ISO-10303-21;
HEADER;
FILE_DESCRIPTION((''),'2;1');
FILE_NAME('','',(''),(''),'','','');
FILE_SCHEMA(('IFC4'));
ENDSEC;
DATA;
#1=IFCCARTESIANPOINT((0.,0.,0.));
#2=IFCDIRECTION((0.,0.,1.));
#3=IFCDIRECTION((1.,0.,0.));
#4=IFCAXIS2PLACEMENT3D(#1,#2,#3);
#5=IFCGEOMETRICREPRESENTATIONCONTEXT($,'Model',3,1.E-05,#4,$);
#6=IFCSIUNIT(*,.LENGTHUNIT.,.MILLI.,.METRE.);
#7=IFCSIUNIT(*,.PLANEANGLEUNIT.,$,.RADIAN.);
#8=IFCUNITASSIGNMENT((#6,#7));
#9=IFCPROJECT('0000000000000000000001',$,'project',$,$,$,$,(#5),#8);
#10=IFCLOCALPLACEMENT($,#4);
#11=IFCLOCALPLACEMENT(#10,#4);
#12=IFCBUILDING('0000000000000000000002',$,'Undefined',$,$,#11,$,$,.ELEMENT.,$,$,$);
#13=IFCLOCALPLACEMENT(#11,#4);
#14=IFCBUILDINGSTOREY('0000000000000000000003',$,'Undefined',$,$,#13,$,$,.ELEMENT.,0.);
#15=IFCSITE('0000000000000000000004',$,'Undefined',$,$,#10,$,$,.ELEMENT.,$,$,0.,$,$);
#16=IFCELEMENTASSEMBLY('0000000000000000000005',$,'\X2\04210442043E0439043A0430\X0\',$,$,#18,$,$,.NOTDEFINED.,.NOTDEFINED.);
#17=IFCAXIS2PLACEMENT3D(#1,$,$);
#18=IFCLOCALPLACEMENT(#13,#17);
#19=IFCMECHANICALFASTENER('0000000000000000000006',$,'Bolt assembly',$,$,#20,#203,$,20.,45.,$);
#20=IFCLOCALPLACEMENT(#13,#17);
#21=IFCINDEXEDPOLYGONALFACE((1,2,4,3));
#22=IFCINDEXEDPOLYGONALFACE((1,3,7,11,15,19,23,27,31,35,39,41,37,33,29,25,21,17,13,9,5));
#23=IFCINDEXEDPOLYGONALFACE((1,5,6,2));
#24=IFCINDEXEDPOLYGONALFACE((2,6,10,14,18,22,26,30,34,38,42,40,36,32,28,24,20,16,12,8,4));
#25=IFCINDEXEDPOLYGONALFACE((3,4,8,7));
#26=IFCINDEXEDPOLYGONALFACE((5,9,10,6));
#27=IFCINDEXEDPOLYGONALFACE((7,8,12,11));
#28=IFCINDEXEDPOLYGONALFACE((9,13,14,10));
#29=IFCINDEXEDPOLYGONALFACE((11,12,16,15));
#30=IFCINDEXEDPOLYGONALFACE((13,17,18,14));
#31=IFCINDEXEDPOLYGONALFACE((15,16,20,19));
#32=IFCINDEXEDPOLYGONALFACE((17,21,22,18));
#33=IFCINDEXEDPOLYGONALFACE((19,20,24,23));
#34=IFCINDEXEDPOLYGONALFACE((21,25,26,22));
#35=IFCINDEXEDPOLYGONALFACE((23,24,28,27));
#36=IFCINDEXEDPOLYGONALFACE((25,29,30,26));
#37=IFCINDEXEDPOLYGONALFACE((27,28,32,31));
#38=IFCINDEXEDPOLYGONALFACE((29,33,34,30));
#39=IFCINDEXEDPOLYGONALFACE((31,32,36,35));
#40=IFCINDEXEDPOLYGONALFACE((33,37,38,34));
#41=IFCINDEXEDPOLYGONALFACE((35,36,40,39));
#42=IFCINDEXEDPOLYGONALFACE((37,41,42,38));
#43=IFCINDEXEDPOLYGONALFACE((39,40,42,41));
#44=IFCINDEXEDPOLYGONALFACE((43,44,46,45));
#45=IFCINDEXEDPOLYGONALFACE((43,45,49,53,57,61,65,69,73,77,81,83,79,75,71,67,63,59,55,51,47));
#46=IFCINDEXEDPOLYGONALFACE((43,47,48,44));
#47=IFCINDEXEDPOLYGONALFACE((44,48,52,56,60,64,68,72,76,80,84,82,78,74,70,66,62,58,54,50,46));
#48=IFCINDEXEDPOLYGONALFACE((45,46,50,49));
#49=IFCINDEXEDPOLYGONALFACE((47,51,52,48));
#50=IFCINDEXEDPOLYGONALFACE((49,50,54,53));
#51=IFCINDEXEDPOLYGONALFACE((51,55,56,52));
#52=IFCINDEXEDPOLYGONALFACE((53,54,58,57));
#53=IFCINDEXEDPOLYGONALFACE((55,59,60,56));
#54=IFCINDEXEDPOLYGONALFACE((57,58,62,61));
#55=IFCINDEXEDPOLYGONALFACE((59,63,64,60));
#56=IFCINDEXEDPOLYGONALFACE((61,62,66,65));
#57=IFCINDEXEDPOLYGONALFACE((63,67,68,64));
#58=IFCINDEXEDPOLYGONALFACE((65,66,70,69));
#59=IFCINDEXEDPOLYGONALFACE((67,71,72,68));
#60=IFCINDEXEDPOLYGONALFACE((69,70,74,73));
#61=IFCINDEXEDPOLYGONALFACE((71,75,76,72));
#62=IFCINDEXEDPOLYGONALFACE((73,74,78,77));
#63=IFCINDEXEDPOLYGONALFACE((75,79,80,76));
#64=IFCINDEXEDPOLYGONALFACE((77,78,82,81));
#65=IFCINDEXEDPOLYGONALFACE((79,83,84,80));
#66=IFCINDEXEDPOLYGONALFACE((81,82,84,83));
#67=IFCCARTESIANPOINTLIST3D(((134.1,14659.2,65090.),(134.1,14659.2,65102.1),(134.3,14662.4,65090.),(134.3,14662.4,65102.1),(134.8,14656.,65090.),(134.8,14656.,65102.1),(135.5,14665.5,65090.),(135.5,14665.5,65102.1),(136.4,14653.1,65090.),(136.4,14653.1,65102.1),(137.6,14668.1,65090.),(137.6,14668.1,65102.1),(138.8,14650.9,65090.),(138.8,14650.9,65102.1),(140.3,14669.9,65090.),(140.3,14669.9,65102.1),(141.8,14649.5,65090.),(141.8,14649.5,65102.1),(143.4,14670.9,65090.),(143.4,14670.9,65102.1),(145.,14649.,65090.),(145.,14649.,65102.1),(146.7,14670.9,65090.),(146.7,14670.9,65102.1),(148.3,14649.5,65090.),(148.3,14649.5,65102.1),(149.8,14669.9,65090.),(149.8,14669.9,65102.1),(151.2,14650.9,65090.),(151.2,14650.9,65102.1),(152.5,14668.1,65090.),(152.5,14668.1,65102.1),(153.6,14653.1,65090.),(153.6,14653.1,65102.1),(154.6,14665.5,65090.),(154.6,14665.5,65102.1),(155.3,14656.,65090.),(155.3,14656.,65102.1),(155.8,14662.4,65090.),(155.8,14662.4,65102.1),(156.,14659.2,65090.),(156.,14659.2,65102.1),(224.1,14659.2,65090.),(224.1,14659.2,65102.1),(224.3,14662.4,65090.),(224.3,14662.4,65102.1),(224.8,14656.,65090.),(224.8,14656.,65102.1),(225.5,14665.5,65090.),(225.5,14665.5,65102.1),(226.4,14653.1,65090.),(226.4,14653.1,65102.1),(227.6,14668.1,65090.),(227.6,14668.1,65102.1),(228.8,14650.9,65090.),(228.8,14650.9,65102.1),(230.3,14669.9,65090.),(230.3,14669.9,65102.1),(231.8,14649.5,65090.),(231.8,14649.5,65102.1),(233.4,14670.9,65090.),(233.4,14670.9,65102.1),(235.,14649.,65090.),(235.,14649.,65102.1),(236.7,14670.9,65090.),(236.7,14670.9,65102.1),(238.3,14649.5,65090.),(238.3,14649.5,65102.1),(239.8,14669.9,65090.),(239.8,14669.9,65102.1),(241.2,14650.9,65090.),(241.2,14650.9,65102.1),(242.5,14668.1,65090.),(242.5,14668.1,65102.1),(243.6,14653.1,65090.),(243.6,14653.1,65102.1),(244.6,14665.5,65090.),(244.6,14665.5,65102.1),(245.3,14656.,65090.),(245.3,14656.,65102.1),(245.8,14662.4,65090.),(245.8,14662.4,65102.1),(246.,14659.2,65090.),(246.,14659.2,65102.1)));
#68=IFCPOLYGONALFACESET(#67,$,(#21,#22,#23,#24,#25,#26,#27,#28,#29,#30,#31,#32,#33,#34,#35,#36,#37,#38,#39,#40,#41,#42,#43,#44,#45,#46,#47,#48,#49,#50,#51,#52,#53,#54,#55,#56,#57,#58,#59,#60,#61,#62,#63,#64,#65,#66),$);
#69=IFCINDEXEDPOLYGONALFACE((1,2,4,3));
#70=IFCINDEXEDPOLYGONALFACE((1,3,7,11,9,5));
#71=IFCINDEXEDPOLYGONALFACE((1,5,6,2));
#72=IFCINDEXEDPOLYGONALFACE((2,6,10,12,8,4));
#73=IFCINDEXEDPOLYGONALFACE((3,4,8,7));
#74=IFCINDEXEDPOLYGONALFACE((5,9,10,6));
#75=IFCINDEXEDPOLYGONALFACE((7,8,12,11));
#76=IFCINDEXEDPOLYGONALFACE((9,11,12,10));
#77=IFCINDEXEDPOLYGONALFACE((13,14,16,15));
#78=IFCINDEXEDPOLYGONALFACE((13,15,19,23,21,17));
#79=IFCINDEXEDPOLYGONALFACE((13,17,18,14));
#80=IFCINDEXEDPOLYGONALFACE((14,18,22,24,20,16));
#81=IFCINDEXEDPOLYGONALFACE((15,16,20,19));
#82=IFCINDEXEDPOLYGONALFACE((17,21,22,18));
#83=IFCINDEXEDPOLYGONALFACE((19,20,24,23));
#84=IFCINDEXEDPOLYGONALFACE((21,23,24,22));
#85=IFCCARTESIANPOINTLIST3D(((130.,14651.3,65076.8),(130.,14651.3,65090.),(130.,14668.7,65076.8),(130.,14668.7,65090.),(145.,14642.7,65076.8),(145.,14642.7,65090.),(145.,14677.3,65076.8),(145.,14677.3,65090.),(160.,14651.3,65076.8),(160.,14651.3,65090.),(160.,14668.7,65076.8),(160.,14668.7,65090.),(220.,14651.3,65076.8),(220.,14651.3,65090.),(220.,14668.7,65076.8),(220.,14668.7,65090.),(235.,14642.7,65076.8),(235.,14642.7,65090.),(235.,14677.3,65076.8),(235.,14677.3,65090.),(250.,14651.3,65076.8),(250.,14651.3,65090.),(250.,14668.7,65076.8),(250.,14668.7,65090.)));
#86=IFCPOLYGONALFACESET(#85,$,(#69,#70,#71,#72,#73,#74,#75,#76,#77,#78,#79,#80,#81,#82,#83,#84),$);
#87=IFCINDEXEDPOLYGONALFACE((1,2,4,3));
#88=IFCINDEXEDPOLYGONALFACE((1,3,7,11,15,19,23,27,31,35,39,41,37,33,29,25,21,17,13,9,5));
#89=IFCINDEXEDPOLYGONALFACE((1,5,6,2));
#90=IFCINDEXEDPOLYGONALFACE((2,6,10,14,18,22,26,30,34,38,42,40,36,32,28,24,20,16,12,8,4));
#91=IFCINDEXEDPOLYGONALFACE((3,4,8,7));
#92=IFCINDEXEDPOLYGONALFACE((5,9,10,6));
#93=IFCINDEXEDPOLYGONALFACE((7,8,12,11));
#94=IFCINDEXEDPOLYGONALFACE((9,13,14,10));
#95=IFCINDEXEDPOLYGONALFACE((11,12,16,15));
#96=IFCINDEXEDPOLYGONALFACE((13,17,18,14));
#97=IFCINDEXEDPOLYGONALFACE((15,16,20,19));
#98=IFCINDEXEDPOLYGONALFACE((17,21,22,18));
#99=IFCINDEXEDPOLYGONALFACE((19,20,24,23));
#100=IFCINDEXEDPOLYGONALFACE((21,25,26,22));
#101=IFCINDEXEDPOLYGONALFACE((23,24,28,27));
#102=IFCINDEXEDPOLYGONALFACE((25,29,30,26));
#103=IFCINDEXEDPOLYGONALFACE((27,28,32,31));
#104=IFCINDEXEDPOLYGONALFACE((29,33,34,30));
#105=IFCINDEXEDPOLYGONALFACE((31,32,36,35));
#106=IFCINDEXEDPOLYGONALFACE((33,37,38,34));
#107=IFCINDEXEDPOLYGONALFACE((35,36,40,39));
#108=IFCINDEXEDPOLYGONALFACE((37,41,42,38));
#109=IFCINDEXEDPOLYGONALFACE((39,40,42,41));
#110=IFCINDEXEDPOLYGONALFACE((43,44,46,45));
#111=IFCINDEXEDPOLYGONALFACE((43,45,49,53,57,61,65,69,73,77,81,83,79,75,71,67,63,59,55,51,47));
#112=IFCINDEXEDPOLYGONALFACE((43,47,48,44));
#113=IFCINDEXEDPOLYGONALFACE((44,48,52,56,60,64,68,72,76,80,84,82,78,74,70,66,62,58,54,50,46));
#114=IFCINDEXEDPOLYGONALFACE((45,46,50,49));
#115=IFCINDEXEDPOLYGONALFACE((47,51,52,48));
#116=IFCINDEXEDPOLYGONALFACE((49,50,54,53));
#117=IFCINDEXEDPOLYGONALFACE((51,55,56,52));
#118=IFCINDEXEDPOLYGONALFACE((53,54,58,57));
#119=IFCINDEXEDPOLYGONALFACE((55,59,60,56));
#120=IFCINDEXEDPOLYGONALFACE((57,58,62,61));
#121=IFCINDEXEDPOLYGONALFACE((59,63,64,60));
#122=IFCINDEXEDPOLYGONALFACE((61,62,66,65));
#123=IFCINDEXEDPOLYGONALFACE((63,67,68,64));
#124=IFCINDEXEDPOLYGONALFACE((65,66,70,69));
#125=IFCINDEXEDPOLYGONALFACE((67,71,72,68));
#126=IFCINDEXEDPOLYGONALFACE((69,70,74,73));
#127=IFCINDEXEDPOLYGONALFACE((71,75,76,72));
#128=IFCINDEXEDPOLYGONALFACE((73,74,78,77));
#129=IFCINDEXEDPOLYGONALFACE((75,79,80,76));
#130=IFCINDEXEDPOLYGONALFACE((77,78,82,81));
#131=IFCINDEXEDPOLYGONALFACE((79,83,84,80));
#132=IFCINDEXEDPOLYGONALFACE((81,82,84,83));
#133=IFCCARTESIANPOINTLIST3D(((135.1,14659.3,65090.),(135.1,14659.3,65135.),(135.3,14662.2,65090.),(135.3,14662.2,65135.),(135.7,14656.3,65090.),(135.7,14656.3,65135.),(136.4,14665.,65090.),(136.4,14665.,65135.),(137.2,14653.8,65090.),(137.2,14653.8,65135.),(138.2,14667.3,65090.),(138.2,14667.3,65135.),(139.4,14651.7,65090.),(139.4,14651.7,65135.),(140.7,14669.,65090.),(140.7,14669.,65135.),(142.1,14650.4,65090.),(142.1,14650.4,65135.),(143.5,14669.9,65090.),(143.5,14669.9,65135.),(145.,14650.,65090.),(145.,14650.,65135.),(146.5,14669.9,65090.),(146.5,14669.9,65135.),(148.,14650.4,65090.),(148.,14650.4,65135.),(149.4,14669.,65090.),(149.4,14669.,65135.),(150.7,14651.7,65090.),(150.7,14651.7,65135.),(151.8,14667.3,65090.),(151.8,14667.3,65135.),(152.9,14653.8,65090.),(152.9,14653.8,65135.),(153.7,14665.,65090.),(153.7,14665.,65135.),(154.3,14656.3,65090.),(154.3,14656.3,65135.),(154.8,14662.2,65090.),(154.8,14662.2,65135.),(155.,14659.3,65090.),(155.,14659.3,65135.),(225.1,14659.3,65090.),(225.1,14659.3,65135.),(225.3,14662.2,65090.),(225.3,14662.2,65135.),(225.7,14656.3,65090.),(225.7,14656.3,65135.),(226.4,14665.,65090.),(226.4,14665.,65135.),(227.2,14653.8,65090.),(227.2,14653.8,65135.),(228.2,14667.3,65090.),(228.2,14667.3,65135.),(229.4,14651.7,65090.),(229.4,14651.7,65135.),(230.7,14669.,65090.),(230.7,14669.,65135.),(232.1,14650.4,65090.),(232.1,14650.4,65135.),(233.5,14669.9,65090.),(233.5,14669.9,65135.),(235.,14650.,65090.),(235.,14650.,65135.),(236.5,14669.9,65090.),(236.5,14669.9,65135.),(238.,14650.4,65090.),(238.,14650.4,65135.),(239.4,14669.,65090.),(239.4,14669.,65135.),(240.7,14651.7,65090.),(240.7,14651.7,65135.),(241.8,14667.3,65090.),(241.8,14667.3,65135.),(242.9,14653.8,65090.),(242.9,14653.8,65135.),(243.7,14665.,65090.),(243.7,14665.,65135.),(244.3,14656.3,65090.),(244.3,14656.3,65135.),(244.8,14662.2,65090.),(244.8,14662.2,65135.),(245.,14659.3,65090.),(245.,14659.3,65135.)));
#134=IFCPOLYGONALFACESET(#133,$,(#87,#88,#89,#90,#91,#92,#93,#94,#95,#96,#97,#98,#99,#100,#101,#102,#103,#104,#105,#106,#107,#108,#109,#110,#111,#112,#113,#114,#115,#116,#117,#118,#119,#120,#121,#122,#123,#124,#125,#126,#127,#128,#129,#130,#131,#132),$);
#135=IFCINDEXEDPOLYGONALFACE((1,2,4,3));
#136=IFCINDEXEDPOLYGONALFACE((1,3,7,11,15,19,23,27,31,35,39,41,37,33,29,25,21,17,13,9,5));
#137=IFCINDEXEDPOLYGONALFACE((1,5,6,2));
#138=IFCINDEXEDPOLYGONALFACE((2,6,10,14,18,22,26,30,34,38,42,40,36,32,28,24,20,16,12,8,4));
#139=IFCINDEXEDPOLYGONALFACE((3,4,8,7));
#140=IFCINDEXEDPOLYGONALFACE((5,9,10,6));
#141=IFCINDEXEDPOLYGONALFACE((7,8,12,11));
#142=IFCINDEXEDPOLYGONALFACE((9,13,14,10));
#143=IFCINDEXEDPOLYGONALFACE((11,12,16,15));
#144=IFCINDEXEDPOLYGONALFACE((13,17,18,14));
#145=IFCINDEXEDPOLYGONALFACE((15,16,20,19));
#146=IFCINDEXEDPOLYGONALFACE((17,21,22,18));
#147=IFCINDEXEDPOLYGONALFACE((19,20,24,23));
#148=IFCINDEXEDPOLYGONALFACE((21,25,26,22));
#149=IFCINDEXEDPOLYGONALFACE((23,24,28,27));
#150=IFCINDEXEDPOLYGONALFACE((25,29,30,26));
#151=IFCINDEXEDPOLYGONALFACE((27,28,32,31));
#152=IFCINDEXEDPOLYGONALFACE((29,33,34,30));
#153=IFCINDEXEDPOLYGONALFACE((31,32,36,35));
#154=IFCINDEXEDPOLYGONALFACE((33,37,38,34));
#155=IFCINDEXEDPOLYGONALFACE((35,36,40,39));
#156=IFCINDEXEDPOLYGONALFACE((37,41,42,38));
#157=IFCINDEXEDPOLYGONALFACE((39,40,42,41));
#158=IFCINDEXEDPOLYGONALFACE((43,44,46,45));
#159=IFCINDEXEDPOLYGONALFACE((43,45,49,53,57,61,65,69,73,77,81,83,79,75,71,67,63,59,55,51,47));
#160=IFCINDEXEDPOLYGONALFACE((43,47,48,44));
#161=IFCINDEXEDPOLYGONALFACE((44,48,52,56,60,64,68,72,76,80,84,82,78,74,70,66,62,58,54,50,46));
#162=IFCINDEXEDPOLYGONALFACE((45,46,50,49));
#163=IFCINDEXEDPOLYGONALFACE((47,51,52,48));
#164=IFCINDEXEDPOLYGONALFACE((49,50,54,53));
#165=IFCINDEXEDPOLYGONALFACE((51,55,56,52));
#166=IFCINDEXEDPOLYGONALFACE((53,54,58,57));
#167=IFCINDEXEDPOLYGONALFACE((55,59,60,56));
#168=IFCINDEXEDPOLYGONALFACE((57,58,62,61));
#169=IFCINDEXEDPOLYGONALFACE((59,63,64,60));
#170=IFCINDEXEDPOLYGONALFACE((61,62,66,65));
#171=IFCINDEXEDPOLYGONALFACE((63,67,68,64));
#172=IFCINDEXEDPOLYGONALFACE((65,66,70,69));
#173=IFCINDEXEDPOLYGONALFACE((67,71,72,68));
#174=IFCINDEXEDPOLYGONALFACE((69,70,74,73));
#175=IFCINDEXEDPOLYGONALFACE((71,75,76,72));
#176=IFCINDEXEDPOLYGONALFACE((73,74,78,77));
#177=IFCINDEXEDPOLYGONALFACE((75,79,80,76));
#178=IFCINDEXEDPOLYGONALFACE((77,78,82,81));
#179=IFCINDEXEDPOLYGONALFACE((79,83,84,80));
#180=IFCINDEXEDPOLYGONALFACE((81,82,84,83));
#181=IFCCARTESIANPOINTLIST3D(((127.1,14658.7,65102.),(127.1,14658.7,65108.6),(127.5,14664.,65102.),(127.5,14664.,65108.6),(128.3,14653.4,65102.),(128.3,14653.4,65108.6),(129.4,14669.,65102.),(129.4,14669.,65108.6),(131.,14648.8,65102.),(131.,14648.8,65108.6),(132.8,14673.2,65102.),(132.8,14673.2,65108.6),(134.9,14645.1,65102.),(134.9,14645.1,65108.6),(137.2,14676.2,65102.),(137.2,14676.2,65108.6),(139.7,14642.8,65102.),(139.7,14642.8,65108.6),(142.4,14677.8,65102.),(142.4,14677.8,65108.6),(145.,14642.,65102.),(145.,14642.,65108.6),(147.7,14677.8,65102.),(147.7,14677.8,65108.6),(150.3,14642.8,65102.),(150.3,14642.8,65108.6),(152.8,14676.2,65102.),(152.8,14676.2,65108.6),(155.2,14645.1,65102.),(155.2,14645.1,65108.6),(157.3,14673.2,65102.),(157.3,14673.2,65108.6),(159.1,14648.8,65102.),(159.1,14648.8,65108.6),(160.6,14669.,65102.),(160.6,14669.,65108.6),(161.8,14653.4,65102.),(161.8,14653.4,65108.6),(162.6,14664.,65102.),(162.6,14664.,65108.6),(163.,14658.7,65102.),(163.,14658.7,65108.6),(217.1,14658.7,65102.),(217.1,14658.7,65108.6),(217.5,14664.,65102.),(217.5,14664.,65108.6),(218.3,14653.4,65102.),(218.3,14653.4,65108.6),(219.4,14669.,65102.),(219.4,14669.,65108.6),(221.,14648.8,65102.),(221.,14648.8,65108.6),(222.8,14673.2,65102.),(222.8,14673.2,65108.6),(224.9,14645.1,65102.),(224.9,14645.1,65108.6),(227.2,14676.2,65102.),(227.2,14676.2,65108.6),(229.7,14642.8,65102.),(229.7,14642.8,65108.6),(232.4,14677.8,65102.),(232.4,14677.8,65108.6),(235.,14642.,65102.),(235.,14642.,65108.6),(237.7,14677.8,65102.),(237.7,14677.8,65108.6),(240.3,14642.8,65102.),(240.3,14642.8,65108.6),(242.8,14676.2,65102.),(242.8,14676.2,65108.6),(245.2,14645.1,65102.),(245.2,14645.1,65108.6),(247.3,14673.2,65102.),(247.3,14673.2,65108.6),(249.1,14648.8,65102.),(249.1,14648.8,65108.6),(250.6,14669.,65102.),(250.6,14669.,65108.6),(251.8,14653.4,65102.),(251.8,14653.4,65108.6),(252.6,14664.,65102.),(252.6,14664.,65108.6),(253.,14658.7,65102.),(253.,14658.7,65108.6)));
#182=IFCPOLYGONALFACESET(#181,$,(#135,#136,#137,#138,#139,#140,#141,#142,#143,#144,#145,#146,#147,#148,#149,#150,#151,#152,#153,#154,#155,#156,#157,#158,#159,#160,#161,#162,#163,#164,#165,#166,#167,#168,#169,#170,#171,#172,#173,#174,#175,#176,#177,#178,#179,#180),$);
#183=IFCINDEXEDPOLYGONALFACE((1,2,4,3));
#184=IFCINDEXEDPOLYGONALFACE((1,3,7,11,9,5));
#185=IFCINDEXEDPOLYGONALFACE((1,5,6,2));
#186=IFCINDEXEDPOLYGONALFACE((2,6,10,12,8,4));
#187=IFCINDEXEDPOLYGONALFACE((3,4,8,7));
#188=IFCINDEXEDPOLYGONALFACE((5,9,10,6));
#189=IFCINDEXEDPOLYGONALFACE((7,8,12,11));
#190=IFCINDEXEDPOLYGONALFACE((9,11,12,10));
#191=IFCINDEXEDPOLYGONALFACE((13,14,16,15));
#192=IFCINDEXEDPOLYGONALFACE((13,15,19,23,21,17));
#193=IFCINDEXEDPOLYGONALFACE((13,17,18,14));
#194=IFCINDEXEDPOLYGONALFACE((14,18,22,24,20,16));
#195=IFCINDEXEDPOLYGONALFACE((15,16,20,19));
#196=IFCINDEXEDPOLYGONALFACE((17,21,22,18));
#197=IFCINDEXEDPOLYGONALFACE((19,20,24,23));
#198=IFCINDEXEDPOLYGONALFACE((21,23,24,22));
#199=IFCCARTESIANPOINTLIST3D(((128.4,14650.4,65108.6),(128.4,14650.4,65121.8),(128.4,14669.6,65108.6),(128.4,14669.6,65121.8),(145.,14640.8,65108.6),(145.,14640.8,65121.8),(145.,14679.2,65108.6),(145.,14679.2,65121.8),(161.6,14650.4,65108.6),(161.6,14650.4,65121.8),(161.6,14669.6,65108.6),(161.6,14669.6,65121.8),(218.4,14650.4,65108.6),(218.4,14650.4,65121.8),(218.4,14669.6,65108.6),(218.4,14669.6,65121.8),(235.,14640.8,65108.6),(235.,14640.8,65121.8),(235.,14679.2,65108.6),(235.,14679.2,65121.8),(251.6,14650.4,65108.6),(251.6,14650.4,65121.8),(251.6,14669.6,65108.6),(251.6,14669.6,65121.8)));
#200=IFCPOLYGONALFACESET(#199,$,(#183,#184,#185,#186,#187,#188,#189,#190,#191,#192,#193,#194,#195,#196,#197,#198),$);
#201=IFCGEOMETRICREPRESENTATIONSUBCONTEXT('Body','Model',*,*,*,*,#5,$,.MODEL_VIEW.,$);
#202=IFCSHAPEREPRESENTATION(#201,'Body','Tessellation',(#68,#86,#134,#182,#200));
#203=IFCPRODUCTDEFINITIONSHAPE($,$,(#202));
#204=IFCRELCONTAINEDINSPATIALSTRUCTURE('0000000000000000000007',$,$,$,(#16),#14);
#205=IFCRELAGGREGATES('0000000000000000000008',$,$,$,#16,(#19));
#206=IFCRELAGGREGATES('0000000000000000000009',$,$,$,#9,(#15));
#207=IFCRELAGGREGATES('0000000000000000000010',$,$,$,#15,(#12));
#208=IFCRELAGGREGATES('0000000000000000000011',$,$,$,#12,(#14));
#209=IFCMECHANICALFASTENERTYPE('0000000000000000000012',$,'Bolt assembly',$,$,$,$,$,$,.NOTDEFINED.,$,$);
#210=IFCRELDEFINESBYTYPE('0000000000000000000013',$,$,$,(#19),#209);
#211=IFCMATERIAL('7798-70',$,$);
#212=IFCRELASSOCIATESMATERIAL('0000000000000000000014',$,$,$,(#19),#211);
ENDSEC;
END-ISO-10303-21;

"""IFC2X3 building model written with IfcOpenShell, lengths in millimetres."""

from ifc_helpers import new_model, si_unit, frame, origin_with_axes, origin_2d_with_axis, place, context, subcontext, project, spatial, polyline, circle, outline, extrude, source, transform, mapped, material, type_object, element, aggregate, save


model = new_model("IFC2X3")

# Units and contexts
model_context = context("Model", 3, precision=1e-05, world=origin_with_axes())
body_context = subcontext(model_context, "Body", "Model", "MODEL_VIEW")
ifc_project = project(units=[si_unit("LENGTHUNIT", "METRE", prefix="MILLI"), si_unit("PLANEANGLEUNIT", "RADIAN")], contexts=[model_context])

# Site, building, storey
site_placement = place(None, origin_with_axes())
site = spatial("IfcSite", under=ifc_project, at=site_placement, Name="Undefined", CompositionType="ELEMENT", RefElevation=0.0)
building_placement = place(site_placement, origin_with_axes())
building = spatial("IfcBuilding", under=site, at=building_placement, Name="Undefined", CompositionType="ELEMENT")
storey_placement = place(building_placement, origin_with_axes())
storey = spatial("IfcBuildingStorey", under=building, at=storey_placement, Name="Undefined", CompositionType="ELEMENT", Elevation=0.0)

# Element assembly
assembly_1_placement = place(storey_placement, origin_with_axes())
assembly_1 = element("IfcElementAssembly", 1, at=assembly_1_placement, inside=storey, Name="Стойка", AssemblyPlace="NOTDEFINED", PredefinedType="NOTDEFINED")

# Shared definitions
ifc_material_1 = material(Name="7798-70")
mechanical_fastener_type = type_object("IfcMechanicalFastenerType", Name="Bolt assembly")

# Mechanical fastener
shared_shape_1 = source(origin_with_axes(), body_context, "Body", "SweptSolid", [
    extrude(circle(Radius=11.0, at=origin_2d_with_axis()), frame((0.0, -0.5, 0.0), z_axis=(0.0, 1.0, 0.0), x_axis=(1.0, 0.0, 0.0)), (0.0, 0.0, 1.0), 12.1),
    extrude(outline(polyline([(17.3, 0.0), (8.7, 15.0), (-8.7, 15.0), (-17.3, 0.0), (-8.7, -15.0), (8.7, -15.0), (17.3, 0.0)])), frame((0.0, -13.7, 0.0), z_axis=(0.0, 1.0, 0.0), x_axis=(1.0, 0.0, 0.0)), (0.0, 0.0, 1.0), 13.2),
    extrude(circle(Radius=10.0, at=origin_2d_with_axis()), frame((0.0, -0.5, 0.0), z_axis=(0.0, 1.0, 0.0), x_axis=(1.0, 0.0, 0.0)), (0.0, 0.0, 1.0), 45.0),
    extrude(circle(Radius=18.0, at=origin_2d_with_axis()), frame((0.0, 11.5, 0.0), z_axis=(0.0, 1.0, 0.0), x_axis=(1.0, 0.0, 0.0)), (0.0, 0.0, 1.0), 6.6),
    extrude(outline(polyline([(19.2, 0.0), (9.6, 16.6), (-9.6, 16.6), (-19.2, 0.0), (-9.6, -16.6), (9.6, -16.6), (19.2, 0.0)])), frame((0.0, 18.1, 0.0), z_axis=(0.0, 1.0, 0.0), x_axis=(1.0, 0.0, 0.0)), (0.0, 0.0, 1.0), 13.2),
])
mechanical_fastener_1_placement = place(assembly_1_placement, frame((190.0, 14910.0, 65090.5), z_axis=(-1.0, 0.0, 0.0), x_axis=(0.0, -1.0, 0.0)))
mechanical_fastener_1 = element("IfcMechanicalFastener", 2, at=mechanical_fastener_1_placement, type_object=mechanical_fastener_type, material=ifc_material_1, Name="Bolt assembly", NominalDiameter=20.0, NominalLength=45.0, context=body_context, shape_type="MappedRepresentation", body=[
    mapped(shared_shape_1, transform((250.0, 0.0, -45.0))),
    mapped(shared_shape_1, transform((250.0, 0.0, 45.0))),
])
aggregate(assembly_1, [mechanical_fastener_1])

save(model, "model.ifc")
